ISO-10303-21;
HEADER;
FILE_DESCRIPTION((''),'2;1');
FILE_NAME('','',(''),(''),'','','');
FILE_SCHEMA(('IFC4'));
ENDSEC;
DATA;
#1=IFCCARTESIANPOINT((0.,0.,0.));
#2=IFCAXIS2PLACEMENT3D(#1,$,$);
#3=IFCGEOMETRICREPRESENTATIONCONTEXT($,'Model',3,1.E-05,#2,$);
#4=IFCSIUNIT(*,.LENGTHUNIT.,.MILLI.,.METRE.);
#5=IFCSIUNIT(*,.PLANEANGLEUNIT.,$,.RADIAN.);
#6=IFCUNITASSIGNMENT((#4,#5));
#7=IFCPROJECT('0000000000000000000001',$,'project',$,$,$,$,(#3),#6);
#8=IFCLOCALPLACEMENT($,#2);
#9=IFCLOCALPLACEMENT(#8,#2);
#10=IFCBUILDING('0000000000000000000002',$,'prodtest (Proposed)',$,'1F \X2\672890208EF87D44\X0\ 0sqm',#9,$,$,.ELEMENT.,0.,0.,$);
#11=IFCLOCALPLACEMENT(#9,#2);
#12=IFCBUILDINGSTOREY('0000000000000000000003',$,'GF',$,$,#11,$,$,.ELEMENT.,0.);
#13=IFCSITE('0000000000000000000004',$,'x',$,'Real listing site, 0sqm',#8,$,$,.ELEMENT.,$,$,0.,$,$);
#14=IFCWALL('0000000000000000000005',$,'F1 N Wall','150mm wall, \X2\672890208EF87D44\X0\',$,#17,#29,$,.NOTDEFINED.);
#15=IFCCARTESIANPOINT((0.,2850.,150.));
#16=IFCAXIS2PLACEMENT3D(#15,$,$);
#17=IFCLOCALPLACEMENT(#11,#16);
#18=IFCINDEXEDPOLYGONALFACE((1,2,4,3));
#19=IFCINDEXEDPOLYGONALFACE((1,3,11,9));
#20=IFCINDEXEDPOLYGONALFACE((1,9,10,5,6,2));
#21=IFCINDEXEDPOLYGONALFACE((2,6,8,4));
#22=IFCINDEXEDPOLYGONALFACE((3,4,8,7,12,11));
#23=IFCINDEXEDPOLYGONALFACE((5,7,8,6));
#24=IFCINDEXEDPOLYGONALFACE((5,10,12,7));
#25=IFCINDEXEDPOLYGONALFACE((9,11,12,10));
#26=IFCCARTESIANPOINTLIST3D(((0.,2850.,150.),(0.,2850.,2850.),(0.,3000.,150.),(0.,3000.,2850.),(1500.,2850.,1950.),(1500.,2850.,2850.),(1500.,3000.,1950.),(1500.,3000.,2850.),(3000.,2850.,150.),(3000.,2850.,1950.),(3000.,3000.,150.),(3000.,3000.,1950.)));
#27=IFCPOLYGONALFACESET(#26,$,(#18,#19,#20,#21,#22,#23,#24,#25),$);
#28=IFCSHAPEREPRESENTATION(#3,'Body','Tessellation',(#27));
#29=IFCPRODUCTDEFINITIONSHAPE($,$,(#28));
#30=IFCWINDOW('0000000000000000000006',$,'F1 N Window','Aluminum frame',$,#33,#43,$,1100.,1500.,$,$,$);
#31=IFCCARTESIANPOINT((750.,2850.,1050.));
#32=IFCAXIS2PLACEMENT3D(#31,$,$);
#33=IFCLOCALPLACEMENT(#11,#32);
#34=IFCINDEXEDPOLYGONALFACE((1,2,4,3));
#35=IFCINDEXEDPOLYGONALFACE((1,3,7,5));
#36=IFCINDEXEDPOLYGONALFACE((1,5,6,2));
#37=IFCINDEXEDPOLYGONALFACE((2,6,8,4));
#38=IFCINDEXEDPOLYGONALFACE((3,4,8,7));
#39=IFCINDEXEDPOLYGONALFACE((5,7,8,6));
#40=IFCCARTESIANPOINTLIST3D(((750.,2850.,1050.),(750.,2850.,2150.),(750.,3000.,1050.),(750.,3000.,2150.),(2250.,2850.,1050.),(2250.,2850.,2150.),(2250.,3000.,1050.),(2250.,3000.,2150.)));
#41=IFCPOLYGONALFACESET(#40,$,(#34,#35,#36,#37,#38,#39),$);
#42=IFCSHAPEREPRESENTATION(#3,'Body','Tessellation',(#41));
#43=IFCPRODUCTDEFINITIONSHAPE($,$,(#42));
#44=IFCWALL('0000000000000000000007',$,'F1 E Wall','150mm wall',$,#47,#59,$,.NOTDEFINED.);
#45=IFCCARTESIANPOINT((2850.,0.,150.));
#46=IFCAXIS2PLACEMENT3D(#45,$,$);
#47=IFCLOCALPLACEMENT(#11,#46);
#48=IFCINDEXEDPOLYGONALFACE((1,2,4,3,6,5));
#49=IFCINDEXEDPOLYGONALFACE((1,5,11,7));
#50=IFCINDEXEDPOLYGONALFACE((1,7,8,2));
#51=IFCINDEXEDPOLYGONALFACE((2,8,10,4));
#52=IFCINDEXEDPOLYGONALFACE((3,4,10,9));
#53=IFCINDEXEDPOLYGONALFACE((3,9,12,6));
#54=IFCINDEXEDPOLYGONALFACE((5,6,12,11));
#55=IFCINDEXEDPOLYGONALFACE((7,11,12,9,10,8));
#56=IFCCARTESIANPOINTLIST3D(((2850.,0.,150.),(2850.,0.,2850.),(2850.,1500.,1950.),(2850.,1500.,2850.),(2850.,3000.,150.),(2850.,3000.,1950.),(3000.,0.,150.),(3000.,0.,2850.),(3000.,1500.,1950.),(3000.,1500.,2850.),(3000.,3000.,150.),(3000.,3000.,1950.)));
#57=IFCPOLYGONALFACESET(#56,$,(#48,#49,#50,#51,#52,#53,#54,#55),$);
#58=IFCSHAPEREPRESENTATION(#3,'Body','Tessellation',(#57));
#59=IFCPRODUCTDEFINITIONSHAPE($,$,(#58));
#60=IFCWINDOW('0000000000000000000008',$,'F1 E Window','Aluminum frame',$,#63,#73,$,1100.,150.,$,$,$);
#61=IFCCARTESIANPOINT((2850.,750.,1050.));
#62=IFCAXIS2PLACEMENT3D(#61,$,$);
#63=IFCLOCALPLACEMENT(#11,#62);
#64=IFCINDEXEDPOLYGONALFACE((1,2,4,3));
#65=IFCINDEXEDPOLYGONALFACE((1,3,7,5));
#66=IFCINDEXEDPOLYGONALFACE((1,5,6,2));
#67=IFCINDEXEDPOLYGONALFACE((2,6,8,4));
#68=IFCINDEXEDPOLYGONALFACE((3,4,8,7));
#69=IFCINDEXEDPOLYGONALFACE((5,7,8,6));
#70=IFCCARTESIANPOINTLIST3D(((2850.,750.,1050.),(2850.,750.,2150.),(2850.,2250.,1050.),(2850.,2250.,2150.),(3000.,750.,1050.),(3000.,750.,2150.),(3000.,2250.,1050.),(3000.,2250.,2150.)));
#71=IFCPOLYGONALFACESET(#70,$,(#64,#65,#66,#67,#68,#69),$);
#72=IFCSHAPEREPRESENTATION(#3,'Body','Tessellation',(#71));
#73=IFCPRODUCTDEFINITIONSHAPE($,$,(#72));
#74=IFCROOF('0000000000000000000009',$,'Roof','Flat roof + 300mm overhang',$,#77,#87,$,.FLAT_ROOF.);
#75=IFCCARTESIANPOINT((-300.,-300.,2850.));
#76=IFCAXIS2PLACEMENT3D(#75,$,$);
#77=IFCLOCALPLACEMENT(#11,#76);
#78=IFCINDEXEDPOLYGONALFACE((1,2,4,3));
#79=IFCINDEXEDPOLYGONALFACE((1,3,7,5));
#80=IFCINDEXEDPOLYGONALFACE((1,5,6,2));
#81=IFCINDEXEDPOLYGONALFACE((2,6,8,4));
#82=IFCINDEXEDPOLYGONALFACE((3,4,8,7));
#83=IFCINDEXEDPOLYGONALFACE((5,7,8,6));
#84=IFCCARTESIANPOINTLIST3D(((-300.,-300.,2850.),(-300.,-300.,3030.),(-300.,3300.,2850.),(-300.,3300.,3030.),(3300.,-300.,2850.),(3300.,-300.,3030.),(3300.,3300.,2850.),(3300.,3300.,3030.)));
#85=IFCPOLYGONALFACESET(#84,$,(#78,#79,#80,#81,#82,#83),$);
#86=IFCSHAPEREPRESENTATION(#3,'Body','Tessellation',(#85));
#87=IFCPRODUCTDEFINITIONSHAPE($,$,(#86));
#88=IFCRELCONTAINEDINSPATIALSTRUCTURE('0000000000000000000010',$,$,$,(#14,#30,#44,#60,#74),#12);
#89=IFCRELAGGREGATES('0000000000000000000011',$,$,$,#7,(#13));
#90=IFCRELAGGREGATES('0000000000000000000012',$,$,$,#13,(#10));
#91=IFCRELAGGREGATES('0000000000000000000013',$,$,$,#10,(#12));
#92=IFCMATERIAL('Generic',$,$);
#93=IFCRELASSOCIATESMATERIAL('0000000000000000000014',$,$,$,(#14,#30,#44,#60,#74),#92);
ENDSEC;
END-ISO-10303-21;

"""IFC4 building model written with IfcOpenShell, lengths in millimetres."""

from ifc_helpers import new_model, si_unit, frame, frame_2d, origin, place, context, project, spatial, rectangle, extrude, material, element, fill, save


model = new_model("IFC4")

# Units and contexts
model_context = context("Model", 3, precision=1e-05, world=origin())
ifc_project = project(units=[si_unit("LENGTHUNIT", "METRE", prefix="MILLI"), si_unit("PLANEANGLEUNIT", "RADIAN")], contexts=[model_context])

# Site, building, storey
site_placement = place(None, origin())
site = spatial("IfcSite", under=ifc_project, at=site_placement, Name="x", ObjectType="Real listing site, 0sqm", CompositionType="ELEMENT", RefElevation=0.0)
building_placement = place(site_placement, origin())
building = spatial("IfcBuilding", under=site, at=building_placement, Name="prodtest (Proposed)", ObjectType="1F 木造軸組 0sqm", CompositionType="ELEMENT", ElevationOfRefHeight=0.0, ElevationOfTerrain=0.0)
storey_placement = place(building_placement, origin())
storey = spatial("IfcBuildingStorey", under=building, at=storey_placement, Name="GF", CompositionType="ELEMENT", Elevation=0.0)

# Wall, opening, window
ifc_material_1 = material(Name="Generic")
wall_1_placement = place(storey_placement, frame((0.0, 2850.0, 150.0)))
wall_1 = element("IfcWall", 1, at=wall_1_placement, inside=storey, material=ifc_material_1, Name="F1 N Wall", Description="150mm wall, 木造軸組", PredefinedType="NOTDEFINED", context=model_context, shape_type="SweptSolid", body=[
    extrude(rectangle(XDim=3000.0, YDim=150.0, at=frame_2d((1500.0, 75.0))), frame((0.0, 2850.0, 150.0)), (0.0, 0.0, 1.0), 2700.0),
])
opening_1_placement = place(storey_placement, frame((750.0, 2850.0, 1050.0)))
opening_1 = element("IfcOpeningElement", 2, at=opening_1_placement, cuts=wall_1, PredefinedType="NOTDEFINED", context=model_context, shape_type="SweptSolid", body=[
    extrude(rectangle(XDim=1500.0, YDim=150.0, at=frame_2d((750.0, 75.0))), frame((750.0, 2850.0, 1050.0)), (0.0, 0.0, 1.0), 1100.0),
])
window_1_placement = place(storey_placement, frame((750.0, 2850.0, 1050.0)))
window_1 = element("IfcWindow", 3, at=window_1_placement, inside=storey, material=ifc_material_1, Name="F1 N Window", Description="Aluminum frame", OverallHeight=1100.0, OverallWidth=1500.0, context=model_context, shape_type="SweptSolid", body=[
    extrude(rectangle(XDim=1500.0, YDim=150.0, at=frame_2d((750.0, 75.0))), frame((750.0, 2850.0, 1050.0)), (0.0, 0.0, 1.0), 1100.0),
])
fill(opening_1, window_1)

# Wall, opening, window
wall_2_placement = place(storey_placement, frame((2850.0, 0.0, 150.0)))
wall_2 = element("IfcWall", 4, at=wall_2_placement, inside=storey, material=ifc_material_1, Name="F1 E Wall", Description="150mm wall", PredefinedType="NOTDEFINED", context=model_context, shape_type="SweptSolid", body=[
    extrude(rectangle(XDim=150.0, YDim=3000.0, at=frame_2d((75.0, 1500.0))), frame((2850.0, 0.0, 150.0)), (0.0, 0.0, 1.0), 2700.0),
])
opening_2_placement = place(storey_placement, frame((2850.0, 750.0, 1050.0)))
opening_2 = element("IfcOpeningElement", 5, at=opening_2_placement, cuts=wall_2, PredefinedType="NOTDEFINED", context=model_context, shape_type="SweptSolid", body=[
    extrude(rectangle(XDim=150.0, YDim=1500.0, at=frame_2d((75.0, 750.0))), frame((2850.0, 750.0, 1050.0)), (0.0, 0.0, 1.0), 1100.0),
])
window_2_placement = place(storey_placement, frame((2850.0, 750.0, 1050.0)))
window_2 = element("IfcWindow", 6, at=window_2_placement, inside=storey, material=ifc_material_1, Name="F1 E Window", Description="Aluminum frame", OverallHeight=1100.0, OverallWidth=150.0, context=model_context, shape_type="SweptSolid", body=[
    extrude(rectangle(XDim=150.0, YDim=1500.0, at=frame_2d((75.0, 750.0))), frame((2850.0, 750.0, 1050.0)), (0.0, 0.0, 1.0), 1100.0),
])
fill(opening_2, window_2)

# Roof
roof_placement = place(storey_placement, frame((-300.0, -300.0, 2850.0)))
element("IfcRoof", 7, at=roof_placement, inside=storey, material=ifc_material_1, Name="Roof", Description="Flat roof + 300mm overhang", PredefinedType="FLAT_ROOF", context=model_context, shape_type="SweptSolid", body=[
    extrude(rectangle(XDim=3600.0, YDim=3600.0, at=frame_2d((1800.0, 1800.0))), frame((-300.0, -300.0, 2850.0)), (0.0, 0.0, 1.0), 180.0),
])

save(model, "model.ifc")
